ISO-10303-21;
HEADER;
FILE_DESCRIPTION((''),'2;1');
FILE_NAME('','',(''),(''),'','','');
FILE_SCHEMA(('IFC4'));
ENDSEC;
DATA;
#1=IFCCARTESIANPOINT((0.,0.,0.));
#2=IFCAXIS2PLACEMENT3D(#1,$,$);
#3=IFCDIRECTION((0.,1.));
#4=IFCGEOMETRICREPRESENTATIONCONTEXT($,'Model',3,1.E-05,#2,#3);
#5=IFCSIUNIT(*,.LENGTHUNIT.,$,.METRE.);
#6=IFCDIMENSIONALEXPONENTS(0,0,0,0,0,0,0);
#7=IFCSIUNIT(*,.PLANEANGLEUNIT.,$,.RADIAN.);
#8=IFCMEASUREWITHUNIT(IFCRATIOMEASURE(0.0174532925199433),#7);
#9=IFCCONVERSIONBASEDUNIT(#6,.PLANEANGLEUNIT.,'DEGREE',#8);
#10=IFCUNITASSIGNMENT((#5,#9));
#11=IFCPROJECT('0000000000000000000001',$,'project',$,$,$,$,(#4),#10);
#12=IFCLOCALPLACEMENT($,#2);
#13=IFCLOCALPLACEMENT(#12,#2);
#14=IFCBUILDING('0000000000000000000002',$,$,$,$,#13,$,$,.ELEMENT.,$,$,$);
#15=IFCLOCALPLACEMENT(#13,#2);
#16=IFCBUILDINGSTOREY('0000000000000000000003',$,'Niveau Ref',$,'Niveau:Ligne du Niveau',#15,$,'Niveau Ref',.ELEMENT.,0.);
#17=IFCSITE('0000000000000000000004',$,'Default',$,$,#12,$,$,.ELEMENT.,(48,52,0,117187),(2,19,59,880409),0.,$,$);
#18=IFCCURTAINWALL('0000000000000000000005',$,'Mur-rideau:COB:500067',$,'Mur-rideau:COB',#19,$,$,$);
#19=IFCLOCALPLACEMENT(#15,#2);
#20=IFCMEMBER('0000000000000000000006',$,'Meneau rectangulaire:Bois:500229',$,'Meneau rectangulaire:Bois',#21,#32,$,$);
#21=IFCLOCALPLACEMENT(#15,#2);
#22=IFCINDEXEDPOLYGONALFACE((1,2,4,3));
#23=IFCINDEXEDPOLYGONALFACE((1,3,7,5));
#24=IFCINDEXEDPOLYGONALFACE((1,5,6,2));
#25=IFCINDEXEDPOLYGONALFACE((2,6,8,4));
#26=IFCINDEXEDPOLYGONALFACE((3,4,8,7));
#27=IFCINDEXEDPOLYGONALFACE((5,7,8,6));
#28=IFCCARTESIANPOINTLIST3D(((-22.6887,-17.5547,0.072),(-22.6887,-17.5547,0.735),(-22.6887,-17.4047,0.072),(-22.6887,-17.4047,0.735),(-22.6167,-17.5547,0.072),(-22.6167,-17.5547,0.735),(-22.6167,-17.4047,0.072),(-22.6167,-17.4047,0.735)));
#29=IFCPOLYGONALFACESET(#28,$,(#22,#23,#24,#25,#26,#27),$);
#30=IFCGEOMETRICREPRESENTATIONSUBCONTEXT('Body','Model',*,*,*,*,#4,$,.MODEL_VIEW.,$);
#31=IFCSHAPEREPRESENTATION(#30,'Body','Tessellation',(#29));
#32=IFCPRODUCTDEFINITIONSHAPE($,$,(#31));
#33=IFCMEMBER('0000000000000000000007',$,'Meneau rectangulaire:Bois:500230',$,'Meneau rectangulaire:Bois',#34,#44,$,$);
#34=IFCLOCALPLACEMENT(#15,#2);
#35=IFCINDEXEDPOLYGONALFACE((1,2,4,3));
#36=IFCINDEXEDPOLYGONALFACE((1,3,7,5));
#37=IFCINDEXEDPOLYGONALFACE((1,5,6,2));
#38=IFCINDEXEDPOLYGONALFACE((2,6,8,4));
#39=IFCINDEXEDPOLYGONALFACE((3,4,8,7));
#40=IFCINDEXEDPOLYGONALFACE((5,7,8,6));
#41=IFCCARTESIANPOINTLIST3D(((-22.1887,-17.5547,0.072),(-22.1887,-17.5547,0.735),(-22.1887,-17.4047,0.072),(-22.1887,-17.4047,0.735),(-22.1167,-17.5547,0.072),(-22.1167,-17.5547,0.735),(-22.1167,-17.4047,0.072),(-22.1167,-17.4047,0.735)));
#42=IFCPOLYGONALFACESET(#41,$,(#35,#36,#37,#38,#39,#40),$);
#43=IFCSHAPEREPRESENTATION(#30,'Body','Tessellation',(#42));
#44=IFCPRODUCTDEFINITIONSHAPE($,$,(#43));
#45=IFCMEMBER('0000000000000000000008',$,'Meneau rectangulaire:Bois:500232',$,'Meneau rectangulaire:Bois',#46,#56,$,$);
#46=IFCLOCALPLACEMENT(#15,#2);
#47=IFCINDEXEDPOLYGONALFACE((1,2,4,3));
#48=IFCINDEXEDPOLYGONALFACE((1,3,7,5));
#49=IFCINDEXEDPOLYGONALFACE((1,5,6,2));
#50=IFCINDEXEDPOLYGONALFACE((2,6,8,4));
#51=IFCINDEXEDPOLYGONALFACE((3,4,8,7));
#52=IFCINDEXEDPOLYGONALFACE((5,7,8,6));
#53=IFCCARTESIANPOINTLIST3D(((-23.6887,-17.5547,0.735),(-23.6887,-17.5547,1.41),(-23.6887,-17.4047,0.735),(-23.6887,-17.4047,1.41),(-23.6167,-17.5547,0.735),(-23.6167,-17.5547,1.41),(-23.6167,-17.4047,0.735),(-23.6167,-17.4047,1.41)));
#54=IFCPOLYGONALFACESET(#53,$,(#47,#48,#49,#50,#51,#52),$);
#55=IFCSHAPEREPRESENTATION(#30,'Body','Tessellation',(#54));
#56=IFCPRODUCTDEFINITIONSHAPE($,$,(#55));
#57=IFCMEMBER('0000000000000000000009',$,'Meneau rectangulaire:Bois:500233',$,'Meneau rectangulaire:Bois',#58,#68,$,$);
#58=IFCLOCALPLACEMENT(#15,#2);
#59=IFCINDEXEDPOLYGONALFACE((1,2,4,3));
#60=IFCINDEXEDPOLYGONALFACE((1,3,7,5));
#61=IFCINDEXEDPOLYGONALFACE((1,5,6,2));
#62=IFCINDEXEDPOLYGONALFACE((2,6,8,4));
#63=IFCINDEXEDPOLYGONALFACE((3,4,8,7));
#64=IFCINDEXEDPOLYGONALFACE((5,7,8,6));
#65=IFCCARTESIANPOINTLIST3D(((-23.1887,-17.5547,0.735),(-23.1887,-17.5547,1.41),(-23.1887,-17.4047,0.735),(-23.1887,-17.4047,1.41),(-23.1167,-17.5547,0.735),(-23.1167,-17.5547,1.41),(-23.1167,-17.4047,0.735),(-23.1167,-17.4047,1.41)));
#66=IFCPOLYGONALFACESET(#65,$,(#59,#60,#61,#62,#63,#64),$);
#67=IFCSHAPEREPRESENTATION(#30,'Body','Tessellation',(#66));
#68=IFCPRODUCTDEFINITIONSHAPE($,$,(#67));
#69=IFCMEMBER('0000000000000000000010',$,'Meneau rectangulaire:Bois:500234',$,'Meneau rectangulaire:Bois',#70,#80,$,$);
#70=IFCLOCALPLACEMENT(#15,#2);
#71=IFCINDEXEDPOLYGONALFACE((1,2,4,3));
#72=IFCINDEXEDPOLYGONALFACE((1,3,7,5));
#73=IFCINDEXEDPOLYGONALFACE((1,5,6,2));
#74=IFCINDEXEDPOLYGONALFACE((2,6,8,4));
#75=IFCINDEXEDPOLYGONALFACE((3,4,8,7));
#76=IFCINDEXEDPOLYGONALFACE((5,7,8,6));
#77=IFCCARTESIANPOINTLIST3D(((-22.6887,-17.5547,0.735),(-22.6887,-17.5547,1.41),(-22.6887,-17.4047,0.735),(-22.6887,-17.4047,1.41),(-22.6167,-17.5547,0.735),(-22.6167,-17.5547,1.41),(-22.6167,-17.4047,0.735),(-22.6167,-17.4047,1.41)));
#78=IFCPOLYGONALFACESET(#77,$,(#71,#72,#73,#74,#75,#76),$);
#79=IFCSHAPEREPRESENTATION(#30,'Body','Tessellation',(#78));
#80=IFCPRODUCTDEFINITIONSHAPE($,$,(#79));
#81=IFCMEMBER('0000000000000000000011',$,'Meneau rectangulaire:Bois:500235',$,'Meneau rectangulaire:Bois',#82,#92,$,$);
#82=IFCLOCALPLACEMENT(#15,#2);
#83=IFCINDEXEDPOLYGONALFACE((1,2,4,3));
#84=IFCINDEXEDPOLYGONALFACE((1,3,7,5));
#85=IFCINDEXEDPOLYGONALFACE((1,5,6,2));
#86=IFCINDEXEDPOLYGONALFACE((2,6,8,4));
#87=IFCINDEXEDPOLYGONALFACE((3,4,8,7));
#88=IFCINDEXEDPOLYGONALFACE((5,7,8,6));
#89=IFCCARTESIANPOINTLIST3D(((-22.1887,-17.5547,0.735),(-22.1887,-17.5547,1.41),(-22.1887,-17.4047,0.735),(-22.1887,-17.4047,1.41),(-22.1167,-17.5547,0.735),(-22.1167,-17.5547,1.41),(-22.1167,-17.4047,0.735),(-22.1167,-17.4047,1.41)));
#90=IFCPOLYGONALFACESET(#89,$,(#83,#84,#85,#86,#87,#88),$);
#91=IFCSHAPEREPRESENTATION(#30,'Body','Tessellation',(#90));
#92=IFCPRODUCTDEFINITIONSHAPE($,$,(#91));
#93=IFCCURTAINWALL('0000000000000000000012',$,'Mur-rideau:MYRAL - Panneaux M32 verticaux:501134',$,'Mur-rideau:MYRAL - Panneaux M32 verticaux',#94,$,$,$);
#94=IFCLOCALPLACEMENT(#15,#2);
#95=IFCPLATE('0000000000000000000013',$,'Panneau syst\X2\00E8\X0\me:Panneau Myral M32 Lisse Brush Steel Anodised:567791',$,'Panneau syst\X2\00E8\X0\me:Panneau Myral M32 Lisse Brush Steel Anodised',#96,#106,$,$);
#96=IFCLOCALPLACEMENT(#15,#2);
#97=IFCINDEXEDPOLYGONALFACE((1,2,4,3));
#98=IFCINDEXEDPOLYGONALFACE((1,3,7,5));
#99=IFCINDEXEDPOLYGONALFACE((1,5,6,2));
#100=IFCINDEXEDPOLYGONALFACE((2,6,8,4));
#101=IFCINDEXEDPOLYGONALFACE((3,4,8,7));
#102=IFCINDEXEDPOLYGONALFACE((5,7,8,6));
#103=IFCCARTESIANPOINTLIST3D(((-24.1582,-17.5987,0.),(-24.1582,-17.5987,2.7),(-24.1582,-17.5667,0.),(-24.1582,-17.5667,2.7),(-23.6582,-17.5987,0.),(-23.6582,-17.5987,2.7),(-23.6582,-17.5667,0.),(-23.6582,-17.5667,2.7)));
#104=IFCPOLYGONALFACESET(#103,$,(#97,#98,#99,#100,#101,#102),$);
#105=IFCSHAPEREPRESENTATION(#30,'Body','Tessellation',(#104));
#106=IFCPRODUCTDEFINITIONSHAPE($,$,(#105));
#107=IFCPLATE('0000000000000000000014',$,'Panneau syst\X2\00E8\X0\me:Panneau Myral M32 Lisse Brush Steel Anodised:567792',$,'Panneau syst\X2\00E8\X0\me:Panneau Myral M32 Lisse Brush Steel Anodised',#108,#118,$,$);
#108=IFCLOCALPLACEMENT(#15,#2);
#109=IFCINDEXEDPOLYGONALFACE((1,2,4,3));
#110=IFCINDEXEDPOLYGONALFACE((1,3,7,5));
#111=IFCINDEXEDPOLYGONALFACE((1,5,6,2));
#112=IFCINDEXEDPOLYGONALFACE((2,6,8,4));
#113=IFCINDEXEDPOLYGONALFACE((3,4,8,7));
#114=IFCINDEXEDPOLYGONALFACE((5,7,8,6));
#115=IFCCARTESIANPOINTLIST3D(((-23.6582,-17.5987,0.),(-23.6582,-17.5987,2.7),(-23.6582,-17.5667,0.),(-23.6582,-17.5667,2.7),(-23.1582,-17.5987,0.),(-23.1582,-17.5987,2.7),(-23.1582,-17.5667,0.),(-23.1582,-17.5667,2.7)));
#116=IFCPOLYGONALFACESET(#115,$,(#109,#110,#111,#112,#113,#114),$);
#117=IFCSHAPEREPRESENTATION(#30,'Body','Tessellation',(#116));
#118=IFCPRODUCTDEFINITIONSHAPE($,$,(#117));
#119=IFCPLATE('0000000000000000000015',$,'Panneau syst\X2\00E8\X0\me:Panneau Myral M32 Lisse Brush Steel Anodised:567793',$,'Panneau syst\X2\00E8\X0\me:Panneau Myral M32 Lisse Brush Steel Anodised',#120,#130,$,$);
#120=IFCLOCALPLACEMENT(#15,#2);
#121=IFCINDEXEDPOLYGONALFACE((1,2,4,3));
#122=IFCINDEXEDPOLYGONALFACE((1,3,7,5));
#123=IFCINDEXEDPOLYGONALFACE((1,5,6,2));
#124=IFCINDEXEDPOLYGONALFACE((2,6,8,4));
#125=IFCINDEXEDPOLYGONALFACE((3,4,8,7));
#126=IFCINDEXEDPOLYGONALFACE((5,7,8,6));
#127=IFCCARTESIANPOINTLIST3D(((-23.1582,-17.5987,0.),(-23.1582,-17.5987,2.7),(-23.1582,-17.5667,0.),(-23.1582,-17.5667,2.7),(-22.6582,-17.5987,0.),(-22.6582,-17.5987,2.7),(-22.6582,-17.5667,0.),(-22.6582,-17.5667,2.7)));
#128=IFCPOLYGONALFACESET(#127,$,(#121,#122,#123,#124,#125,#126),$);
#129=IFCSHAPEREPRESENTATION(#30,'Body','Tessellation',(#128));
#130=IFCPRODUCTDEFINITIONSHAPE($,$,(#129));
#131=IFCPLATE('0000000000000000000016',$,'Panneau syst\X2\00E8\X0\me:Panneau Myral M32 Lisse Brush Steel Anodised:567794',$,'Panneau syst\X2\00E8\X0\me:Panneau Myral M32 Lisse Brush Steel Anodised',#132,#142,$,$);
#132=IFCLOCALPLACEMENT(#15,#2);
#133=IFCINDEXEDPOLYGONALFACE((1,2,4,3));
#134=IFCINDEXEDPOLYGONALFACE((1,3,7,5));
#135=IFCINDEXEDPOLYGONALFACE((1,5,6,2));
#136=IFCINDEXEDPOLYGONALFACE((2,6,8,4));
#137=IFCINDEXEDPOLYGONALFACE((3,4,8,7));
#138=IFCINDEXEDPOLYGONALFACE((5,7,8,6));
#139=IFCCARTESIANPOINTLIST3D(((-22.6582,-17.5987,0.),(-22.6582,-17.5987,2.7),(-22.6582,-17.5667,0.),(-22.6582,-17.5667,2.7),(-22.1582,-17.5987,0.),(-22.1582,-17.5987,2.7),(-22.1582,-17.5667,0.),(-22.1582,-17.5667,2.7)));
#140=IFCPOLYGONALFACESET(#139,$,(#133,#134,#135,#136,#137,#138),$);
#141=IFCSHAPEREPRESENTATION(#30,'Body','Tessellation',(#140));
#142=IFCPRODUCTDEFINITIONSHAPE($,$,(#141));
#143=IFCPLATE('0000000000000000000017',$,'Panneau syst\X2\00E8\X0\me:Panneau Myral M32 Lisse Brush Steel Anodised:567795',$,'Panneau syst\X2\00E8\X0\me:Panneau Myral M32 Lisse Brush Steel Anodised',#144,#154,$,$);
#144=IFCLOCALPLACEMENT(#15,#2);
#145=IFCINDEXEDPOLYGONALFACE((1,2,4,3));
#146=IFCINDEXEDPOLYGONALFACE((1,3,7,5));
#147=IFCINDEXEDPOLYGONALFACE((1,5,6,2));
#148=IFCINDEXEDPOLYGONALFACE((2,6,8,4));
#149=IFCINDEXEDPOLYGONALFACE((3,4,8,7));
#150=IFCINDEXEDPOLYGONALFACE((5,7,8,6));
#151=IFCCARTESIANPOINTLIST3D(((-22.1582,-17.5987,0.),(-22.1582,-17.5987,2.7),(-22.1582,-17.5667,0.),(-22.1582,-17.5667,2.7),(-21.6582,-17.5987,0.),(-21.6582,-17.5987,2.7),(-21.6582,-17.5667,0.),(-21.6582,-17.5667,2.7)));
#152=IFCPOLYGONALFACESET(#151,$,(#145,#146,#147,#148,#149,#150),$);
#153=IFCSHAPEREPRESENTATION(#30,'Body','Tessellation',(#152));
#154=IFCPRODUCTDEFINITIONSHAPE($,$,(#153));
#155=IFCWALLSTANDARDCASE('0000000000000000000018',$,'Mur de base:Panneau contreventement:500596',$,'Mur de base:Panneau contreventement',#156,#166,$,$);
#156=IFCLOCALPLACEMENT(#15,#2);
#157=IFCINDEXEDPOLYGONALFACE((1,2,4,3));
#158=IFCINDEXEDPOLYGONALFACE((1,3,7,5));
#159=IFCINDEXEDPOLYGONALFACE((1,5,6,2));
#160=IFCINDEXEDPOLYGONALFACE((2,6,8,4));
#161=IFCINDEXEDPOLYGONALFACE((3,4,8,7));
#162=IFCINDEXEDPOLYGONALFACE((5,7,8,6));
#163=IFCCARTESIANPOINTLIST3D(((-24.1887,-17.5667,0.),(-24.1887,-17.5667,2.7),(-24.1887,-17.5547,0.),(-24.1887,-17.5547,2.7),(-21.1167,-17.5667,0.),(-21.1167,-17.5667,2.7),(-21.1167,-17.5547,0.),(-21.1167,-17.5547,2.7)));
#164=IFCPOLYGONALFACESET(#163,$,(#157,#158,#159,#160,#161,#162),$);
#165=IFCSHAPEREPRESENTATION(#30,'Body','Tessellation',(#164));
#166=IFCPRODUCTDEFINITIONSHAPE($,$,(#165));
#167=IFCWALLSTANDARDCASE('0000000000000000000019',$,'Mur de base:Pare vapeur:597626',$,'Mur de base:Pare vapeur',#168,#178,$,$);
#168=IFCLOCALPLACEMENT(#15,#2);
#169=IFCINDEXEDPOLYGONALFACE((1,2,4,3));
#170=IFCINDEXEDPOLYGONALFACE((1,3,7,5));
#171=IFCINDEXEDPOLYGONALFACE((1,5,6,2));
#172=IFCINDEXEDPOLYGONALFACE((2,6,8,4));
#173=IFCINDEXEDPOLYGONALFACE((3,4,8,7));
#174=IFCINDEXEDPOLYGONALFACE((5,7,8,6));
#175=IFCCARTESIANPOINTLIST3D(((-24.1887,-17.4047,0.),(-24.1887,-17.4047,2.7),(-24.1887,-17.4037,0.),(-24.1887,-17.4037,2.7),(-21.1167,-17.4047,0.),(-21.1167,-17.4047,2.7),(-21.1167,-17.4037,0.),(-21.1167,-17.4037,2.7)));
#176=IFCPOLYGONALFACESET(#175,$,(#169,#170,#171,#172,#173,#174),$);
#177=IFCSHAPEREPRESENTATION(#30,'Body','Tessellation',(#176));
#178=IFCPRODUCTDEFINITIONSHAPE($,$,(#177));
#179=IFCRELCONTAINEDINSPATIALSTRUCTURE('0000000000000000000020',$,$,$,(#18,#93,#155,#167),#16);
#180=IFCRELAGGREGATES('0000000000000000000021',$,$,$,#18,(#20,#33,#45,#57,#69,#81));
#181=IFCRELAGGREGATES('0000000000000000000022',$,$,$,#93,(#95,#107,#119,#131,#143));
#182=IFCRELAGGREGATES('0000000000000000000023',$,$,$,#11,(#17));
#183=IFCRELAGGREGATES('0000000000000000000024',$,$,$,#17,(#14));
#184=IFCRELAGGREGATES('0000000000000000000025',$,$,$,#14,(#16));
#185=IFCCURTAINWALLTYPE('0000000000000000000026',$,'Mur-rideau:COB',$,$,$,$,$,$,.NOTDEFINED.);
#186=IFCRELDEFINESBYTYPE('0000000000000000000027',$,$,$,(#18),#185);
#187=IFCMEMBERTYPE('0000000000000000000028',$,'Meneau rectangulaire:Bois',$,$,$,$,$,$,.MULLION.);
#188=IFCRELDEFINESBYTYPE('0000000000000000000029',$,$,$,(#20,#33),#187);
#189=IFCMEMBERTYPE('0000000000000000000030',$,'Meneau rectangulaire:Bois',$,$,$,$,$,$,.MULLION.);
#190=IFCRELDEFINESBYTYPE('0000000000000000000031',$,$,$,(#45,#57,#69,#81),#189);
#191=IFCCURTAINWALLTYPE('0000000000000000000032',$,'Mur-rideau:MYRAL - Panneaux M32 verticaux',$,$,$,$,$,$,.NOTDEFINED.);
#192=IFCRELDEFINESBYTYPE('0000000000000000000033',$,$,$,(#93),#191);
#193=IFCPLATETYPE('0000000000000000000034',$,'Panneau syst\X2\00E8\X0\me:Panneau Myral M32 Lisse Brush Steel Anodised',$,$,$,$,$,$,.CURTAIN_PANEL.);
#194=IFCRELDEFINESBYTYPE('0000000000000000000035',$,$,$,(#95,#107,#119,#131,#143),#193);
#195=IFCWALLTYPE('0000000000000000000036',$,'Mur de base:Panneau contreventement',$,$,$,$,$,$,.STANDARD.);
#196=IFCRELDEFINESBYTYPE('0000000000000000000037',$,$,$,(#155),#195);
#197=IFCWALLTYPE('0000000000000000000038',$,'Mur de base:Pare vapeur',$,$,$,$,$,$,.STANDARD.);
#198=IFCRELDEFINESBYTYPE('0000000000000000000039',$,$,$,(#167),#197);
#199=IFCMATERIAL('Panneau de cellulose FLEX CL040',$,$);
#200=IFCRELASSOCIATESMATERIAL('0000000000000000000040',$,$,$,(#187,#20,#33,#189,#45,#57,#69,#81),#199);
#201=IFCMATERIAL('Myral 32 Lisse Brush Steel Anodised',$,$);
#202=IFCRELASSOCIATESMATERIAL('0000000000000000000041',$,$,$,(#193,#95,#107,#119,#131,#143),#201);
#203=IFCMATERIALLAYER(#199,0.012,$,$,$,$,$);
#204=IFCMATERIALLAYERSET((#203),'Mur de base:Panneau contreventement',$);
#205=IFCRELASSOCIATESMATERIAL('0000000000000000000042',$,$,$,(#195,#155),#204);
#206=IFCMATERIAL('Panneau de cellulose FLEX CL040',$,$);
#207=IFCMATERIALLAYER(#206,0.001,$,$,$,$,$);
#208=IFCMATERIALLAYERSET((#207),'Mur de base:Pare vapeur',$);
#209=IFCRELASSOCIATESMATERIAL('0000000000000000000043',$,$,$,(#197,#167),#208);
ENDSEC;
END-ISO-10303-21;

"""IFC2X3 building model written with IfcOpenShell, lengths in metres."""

from ifc_helpers import new_model, entity, si_unit, converted_unit, direction, frame, frame_2d, origin, origin_2d_with_axis, place, context, subcontext, project, spatial, rectangle, extrude, source, transform, mapped, material, layer, layer_set, layer_usage, type_object, type_shapes, element, aggregate, save


model = new_model("IFC2X3")

# Units and contexts
model_context = context("Model", 3, precision=1e-05, world=origin(), true_north=direction((0.0, 1.0)))
body_context = subcontext(model_context, "Body", "Model", "MODEL_VIEW")
ifc_project = project(units=[si_unit("LENGTHUNIT", "METRE"), converted_unit("PLANEANGLEUNIT", "DEGREE", entity("IfcRatioMeasure", 0.0174532925199433), si_unit("PLANEANGLEUNIT", "RADIAN"), dimensions=[0, 0, 0, 0, 0, 0, 0])], contexts=[model_context])

# Site, building, storey
site_placement = place(None, origin())
site = spatial("IfcSite", under=ifc_project, at=site_placement, Name="Default", CompositionType="ELEMENT", RefLatitude=(48, 52, 0, 117187), RefLongitude=(2, 19, 59, 880409), RefElevation=0.0)
building_placement = place(site_placement, origin())
building = spatial("IfcBuilding", under=site, at=building_placement, CompositionType="ELEMENT")
storey_placement = place(building_placement, origin())
storey = spatial("IfcBuildingStorey", under=building, at=storey_placement, Name="Niveau Ref", ObjectType="Niveau:Ligne du Niveau", LongName="Niveau Ref", CompositionType="ELEMENT", Elevation=0.0)

# Curtain wall, members
curtain_wall_type_1 = type_object("IfcCurtainWallType", Name="Mur-rideau:COB", PredefinedType="NOTDEFINED")
curtain_wall_1_placement = place(storey_placement, origin())
curtain_wall_1 = element("IfcCurtainWall", 1, at=curtain_wall_1_placement, inside=storey, type_object=curtain_wall_type_1, Name="Mur-rideau:COB:500067", ObjectType="Mur-rideau:COB")
ifc_material_1 = material(Name="Panneau de cellulose FLEX CL040")
member_type_1 = type_object("IfcMemberType", Name="Meneau rectangulaire:Bois", PredefinedType="MULLION", material=ifc_material_1)
shared_shape_1 = source(origin(), body_context, "Body", "SweptSolid", [
    extrude(rectangle(XDim=0.15, YDim=0.072, at=origin_2d_with_axis()), frame((-0.024, 0.0, -0.663), z_axis=(0.0, 0.0, 1.0), x_axis=(0.0, -1.0, 0.0)), (0.0, 0.0, 1.0), 0.663),
])
type_shapes(member_type_1, [shared_shape_1])
member_1_placement = place(storey_placement, frame((-22.6287, -17.4797, 0.072), z_axis=(0.0, 0.0, -1.0), x_axis=(1.0, 0.0, 0.0)))
member_1 = element("IfcMember", 2, at=member_1_placement, type_object=member_type_1, material=ifc_material_1, Name="Meneau rectangulaire:Bois:500229", ObjectType="Meneau rectangulaire:Bois", context=body_context, shape_type="MappedRepresentation", body=[
    mapped(shared_shape_1, transform((0.0, 0.0, 0.0), scale=1.0)),
])
member_2_placement = place(storey_placement, frame((-22.1287, -17.4797, 0.072), z_axis=(0.0, 0.0, -1.0), x_axis=(1.0, 0.0, 0.0)))
member_2 = element("IfcMember", 3, at=member_2_placement, type_object=member_type_1, material=ifc_material_1, Name="Meneau rectangulaire:Bois:500230", ObjectType="Meneau rectangulaire:Bois", context=body_context, shape_type="MappedRepresentation", body=[
    mapped(shared_shape_1, transform((0.0, 0.0, 0.0), scale=1.0)),
])
member_type_2 = type_object("IfcMemberType", Name="Meneau rectangulaire:Bois", PredefinedType="MULLION", material=ifc_material_1)
shared_shape_2 = source(origin(), body_context, "Body", "SweptSolid", [
    extrude(rectangle(XDim=0.15, YDim=0.072, at=origin_2d_with_axis()), frame((-0.024, 0.0, -0.675), z_axis=(0.0, 0.0, 1.0), x_axis=(0.0, -1.0, 0.0)), (0.0, 0.0, 1.0), 0.675),
])
type_shapes(member_type_2, [shared_shape_2])
member_3_placement = place(storey_placement, frame((-23.6287, -17.4797, 0.735), z_axis=(0.0, 0.0, -1.0), x_axis=(1.0, 0.0, 0.0)))
member_3 = element("IfcMember", 4, at=member_3_placement, type_object=member_type_2, material=ifc_material_1, Name="Meneau rectangulaire:Bois:500232", ObjectType="Meneau rectangulaire:Bois", context=body_context, shape_type="MappedRepresentation", body=[
    mapped(shared_shape_2, transform((0.0, 0.0, 0.0), scale=1.0)),
])
member_4_placement = place(storey_placement, frame((-23.1287, -17.4797, 0.735), z_axis=(0.0, 0.0, -1.0), x_axis=(1.0, 0.0, 0.0)))
member_4 = element("IfcMember", 5, at=member_4_placement, type_object=member_type_2, material=ifc_material_1, Name="Meneau rectangulaire:Bois:500233", ObjectType="Meneau rectangulaire:Bois", context=body_context, shape_type="MappedRepresentation", body=[
    mapped(shared_shape_2, transform((0.0, 0.0, 0.0), scale=1.0)),
])
member_5_placement = place(storey_placement, frame((-22.6287, -17.4797, 0.735), z_axis=(0.0, 0.0, -1.0), x_axis=(1.0, 0.0, 0.0)))
member_5 = element("IfcMember", 6, at=member_5_placement, type_object=member_type_2, material=ifc_material_1, Name="Meneau rectangulaire:Bois:500234", ObjectType="Meneau rectangulaire:Bois", context=body_context, shape_type="MappedRepresentation", body=[
    mapped(shared_shape_2, transform((0.0, 0.0, 0.0), scale=1.0)),
])
member_6_placement = place(storey_placement, frame((-22.1287, -17.4797, 0.735), z_axis=(0.0, 0.0, -1.0), x_axis=(1.0, 0.0, 0.0)))
member_6 = element("IfcMember", 7, at=member_6_placement, type_object=member_type_2, material=ifc_material_1, Name="Meneau rectangulaire:Bois:500235", ObjectType="Meneau rectangulaire:Bois", context=body_context, shape_type="MappedRepresentation", body=[
    mapped(shared_shape_2, transform((0.0, 0.0, 0.0), scale=1.0)),
])
aggregate(curtain_wall_1, [member_1, member_2, member_3, member_4, member_5, member_6])

# Curtain wall, plates
curtain_wall_type_2 = type_object("IfcCurtainWallType", Name="Mur-rideau:MYRAL - Panneaux M32 verticaux", PredefinedType="NOTDEFINED")
curtain_wall_2_placement = place(storey_placement, origin())
curtain_wall_2 = element("IfcCurtainWall", 8, at=curtain_wall_2_placement, inside=storey, type_object=curtain_wall_type_2, Name="Mur-rideau:MYRAL - Panneaux M32 verticaux:501134", ObjectType="Mur-rideau:MYRAL - Panneaux M32 verticaux")
ifc_material_2 = material(Name="Myral 32 Lisse Brush Steel Anodised")
plate_type = type_object("IfcPlateType", Name="Panneau système:Panneau Myral M32 Lisse Brush Steel Anodised", PredefinedType="CURTAIN_PANEL", material=ifc_material_2)
shared_shape_3 = source(origin(), body_context, "Body", "SweptSolid", [
    extrude(rectangle(XDim=0.032, YDim=0.5, at=origin_2d_with_axis()), frame((0.0, -0.016, 0.0), z_axis=(0.0, 0.0, 1.0), x_axis=(0.0, 1.0, 0.0)), (0.0, 0.0, 1.0), 2.7),
])
type_shapes(plate_type, [shared_shape_3])
plate_1_placement = place(curtain_wall_2_placement, frame((-23.9082, -17.5667, 0.0)))
plate_1 = element("IfcPlate", 9, at=plate_1_placement, type_object=plate_type, material=ifc_material_2, Name="Panneau système:Panneau Myral M32 Lisse Brush Steel Anodised:567791", ObjectType="Panneau système:Panneau Myral M32 Lisse Brush Steel Anodised", context=body_context, shape_type="MappedRepresentation", body=[
    mapped(shared_shape_3, transform((0.0, 0.0, 0.0), scale=1.0)),
])
plate_2_placement = place(curtain_wall_2_placement, frame((-23.4082, -17.5667, 0.0)))
plate_2 = element("IfcPlate", 10, at=plate_2_placement, type_object=plate_type, material=ifc_material_2, Name="Panneau système:Panneau Myral M32 Lisse Brush Steel Anodised:567792", ObjectType="Panneau système:Panneau Myral M32 Lisse Brush Steel Anodised", context=body_context, shape_type="MappedRepresentation", body=[
    mapped(shared_shape_3, transform((0.0, 0.0, 0.0), scale=1.0)),
])
plate_3_placement = place(curtain_wall_2_placement, frame((-22.9082, -17.5667, 0.0)))
plate_3 = element("IfcPlate", 11, at=plate_3_placement, type_object=plate_type, material=ifc_material_2, Name="Panneau système:Panneau Myral M32 Lisse Brush Steel Anodised:567793", ObjectType="Panneau système:Panneau Myral M32 Lisse Brush Steel Anodised", context=body_context, shape_type="MappedRepresentation", body=[
    mapped(shared_shape_3, transform((0.0, 0.0, 0.0), scale=1.0)),
])
plate_4_placement = place(curtain_wall_2_placement, frame((-22.4082, -17.5667, 0.0)))
plate_4 = element("IfcPlate", 12, at=plate_4_placement, type_object=plate_type, material=ifc_material_2, Name="Panneau système:Panneau Myral M32 Lisse Brush Steel Anodised:567794", ObjectType="Panneau système:Panneau Myral M32 Lisse Brush Steel Anodised", context=body_context, shape_type="MappedRepresentation", body=[
    mapped(shared_shape_3, transform((0.0, 0.0, 0.0), scale=1.0)),
])
plate_5_placement = place(curtain_wall_2_placement, frame((-21.9082, -17.5667, 0.0)))
plate_5 = element("IfcPlate", 13, at=plate_5_placement, type_object=plate_type, material=ifc_material_2, Name="Panneau système:Panneau Myral M32 Lisse Brush Steel Anodised:567795", ObjectType="Panneau système:Panneau Myral M32 Lisse Brush Steel Anodised", context=body_context, shape_type="MappedRepresentation", body=[
    mapped(shared_shape_3, transform((0.0, 0.0, 0.0), scale=1.0)),
])
aggregate(curtain_wall_2, [plate_1, plate_2, plate_3, plate_4, plate_5])

# Walls
ifc_layer_1 = layer(ifc_material_1, 0.012)
ifc_layer_set_1 = layer_set([ifc_layer_1], Name="Mur de base:Panneau contreventement")
ifc_layer_usage_1 = layer_usage(ifc_layer_set_1, "AXIS2", "NEGATIVE", 0.006)
wall_type_1 = type_object("IfcWallType", Name="Mur de base:Panneau contreventement", PredefinedType="STANDARD", material=ifc_layer_set_1)
wall_1_placement = place(storey_placement, frame((-24.1887, -17.5607, 0.0)))
element("IfcWallStandardCase", 14, at=wall_1_placement, inside=storey, type_object=wall_type_1, material=ifc_layer_usage_1, Name="Mur de base:Panneau contreventement:500596", ObjectType="Mur de base:Panneau contreventement", context=body_context, shape_type="SweptSolid", body=[
    extrude(rectangle(XDim=3.072, YDim=0.012, at=frame_2d((1.536, 0.0), x_axis=(-1.0, 0.0))), origin(), (0.0, 0.0, 1.0), 2.7),
])
ifc_material_3 = material(Name="Panneau de cellulose FLEX CL040")
ifc_layer_2 = layer(ifc_material_3, 0.001)
ifc_layer_set_2 = layer_set([ifc_layer_2], Name="Mur de base:Pare vapeur")
ifc_layer_usage_2 = layer_usage(ifc_layer_set_2, "AXIS2", "NEGATIVE", 0.0005)
wall_type_2 = type_object("IfcWallType", Name="Mur de base:Pare vapeur", PredefinedType="STANDARD", material=ifc_layer_set_2)
wall_2_placement = place(storey_placement, frame((-24.1887, -17.4042, 0.0)))
element("IfcWallStandardCase", 15, at=wall_2_placement, inside=storey, type_object=wall_type_2, material=ifc_layer_usage_2, Name="Mur de base:Pare vapeur:597626", ObjectType="Mur de base:Pare vapeur", context=body_context, shape_type="SweptSolid", body=[
    extrude(rectangle(XDim=3.072, YDim=0.001, at=frame_2d((1.536, 0.0), x_axis=(-1.0, 0.0))), origin(), (0.0, 0.0, 1.0), 2.7),
])

save(model, "model.ifc")
